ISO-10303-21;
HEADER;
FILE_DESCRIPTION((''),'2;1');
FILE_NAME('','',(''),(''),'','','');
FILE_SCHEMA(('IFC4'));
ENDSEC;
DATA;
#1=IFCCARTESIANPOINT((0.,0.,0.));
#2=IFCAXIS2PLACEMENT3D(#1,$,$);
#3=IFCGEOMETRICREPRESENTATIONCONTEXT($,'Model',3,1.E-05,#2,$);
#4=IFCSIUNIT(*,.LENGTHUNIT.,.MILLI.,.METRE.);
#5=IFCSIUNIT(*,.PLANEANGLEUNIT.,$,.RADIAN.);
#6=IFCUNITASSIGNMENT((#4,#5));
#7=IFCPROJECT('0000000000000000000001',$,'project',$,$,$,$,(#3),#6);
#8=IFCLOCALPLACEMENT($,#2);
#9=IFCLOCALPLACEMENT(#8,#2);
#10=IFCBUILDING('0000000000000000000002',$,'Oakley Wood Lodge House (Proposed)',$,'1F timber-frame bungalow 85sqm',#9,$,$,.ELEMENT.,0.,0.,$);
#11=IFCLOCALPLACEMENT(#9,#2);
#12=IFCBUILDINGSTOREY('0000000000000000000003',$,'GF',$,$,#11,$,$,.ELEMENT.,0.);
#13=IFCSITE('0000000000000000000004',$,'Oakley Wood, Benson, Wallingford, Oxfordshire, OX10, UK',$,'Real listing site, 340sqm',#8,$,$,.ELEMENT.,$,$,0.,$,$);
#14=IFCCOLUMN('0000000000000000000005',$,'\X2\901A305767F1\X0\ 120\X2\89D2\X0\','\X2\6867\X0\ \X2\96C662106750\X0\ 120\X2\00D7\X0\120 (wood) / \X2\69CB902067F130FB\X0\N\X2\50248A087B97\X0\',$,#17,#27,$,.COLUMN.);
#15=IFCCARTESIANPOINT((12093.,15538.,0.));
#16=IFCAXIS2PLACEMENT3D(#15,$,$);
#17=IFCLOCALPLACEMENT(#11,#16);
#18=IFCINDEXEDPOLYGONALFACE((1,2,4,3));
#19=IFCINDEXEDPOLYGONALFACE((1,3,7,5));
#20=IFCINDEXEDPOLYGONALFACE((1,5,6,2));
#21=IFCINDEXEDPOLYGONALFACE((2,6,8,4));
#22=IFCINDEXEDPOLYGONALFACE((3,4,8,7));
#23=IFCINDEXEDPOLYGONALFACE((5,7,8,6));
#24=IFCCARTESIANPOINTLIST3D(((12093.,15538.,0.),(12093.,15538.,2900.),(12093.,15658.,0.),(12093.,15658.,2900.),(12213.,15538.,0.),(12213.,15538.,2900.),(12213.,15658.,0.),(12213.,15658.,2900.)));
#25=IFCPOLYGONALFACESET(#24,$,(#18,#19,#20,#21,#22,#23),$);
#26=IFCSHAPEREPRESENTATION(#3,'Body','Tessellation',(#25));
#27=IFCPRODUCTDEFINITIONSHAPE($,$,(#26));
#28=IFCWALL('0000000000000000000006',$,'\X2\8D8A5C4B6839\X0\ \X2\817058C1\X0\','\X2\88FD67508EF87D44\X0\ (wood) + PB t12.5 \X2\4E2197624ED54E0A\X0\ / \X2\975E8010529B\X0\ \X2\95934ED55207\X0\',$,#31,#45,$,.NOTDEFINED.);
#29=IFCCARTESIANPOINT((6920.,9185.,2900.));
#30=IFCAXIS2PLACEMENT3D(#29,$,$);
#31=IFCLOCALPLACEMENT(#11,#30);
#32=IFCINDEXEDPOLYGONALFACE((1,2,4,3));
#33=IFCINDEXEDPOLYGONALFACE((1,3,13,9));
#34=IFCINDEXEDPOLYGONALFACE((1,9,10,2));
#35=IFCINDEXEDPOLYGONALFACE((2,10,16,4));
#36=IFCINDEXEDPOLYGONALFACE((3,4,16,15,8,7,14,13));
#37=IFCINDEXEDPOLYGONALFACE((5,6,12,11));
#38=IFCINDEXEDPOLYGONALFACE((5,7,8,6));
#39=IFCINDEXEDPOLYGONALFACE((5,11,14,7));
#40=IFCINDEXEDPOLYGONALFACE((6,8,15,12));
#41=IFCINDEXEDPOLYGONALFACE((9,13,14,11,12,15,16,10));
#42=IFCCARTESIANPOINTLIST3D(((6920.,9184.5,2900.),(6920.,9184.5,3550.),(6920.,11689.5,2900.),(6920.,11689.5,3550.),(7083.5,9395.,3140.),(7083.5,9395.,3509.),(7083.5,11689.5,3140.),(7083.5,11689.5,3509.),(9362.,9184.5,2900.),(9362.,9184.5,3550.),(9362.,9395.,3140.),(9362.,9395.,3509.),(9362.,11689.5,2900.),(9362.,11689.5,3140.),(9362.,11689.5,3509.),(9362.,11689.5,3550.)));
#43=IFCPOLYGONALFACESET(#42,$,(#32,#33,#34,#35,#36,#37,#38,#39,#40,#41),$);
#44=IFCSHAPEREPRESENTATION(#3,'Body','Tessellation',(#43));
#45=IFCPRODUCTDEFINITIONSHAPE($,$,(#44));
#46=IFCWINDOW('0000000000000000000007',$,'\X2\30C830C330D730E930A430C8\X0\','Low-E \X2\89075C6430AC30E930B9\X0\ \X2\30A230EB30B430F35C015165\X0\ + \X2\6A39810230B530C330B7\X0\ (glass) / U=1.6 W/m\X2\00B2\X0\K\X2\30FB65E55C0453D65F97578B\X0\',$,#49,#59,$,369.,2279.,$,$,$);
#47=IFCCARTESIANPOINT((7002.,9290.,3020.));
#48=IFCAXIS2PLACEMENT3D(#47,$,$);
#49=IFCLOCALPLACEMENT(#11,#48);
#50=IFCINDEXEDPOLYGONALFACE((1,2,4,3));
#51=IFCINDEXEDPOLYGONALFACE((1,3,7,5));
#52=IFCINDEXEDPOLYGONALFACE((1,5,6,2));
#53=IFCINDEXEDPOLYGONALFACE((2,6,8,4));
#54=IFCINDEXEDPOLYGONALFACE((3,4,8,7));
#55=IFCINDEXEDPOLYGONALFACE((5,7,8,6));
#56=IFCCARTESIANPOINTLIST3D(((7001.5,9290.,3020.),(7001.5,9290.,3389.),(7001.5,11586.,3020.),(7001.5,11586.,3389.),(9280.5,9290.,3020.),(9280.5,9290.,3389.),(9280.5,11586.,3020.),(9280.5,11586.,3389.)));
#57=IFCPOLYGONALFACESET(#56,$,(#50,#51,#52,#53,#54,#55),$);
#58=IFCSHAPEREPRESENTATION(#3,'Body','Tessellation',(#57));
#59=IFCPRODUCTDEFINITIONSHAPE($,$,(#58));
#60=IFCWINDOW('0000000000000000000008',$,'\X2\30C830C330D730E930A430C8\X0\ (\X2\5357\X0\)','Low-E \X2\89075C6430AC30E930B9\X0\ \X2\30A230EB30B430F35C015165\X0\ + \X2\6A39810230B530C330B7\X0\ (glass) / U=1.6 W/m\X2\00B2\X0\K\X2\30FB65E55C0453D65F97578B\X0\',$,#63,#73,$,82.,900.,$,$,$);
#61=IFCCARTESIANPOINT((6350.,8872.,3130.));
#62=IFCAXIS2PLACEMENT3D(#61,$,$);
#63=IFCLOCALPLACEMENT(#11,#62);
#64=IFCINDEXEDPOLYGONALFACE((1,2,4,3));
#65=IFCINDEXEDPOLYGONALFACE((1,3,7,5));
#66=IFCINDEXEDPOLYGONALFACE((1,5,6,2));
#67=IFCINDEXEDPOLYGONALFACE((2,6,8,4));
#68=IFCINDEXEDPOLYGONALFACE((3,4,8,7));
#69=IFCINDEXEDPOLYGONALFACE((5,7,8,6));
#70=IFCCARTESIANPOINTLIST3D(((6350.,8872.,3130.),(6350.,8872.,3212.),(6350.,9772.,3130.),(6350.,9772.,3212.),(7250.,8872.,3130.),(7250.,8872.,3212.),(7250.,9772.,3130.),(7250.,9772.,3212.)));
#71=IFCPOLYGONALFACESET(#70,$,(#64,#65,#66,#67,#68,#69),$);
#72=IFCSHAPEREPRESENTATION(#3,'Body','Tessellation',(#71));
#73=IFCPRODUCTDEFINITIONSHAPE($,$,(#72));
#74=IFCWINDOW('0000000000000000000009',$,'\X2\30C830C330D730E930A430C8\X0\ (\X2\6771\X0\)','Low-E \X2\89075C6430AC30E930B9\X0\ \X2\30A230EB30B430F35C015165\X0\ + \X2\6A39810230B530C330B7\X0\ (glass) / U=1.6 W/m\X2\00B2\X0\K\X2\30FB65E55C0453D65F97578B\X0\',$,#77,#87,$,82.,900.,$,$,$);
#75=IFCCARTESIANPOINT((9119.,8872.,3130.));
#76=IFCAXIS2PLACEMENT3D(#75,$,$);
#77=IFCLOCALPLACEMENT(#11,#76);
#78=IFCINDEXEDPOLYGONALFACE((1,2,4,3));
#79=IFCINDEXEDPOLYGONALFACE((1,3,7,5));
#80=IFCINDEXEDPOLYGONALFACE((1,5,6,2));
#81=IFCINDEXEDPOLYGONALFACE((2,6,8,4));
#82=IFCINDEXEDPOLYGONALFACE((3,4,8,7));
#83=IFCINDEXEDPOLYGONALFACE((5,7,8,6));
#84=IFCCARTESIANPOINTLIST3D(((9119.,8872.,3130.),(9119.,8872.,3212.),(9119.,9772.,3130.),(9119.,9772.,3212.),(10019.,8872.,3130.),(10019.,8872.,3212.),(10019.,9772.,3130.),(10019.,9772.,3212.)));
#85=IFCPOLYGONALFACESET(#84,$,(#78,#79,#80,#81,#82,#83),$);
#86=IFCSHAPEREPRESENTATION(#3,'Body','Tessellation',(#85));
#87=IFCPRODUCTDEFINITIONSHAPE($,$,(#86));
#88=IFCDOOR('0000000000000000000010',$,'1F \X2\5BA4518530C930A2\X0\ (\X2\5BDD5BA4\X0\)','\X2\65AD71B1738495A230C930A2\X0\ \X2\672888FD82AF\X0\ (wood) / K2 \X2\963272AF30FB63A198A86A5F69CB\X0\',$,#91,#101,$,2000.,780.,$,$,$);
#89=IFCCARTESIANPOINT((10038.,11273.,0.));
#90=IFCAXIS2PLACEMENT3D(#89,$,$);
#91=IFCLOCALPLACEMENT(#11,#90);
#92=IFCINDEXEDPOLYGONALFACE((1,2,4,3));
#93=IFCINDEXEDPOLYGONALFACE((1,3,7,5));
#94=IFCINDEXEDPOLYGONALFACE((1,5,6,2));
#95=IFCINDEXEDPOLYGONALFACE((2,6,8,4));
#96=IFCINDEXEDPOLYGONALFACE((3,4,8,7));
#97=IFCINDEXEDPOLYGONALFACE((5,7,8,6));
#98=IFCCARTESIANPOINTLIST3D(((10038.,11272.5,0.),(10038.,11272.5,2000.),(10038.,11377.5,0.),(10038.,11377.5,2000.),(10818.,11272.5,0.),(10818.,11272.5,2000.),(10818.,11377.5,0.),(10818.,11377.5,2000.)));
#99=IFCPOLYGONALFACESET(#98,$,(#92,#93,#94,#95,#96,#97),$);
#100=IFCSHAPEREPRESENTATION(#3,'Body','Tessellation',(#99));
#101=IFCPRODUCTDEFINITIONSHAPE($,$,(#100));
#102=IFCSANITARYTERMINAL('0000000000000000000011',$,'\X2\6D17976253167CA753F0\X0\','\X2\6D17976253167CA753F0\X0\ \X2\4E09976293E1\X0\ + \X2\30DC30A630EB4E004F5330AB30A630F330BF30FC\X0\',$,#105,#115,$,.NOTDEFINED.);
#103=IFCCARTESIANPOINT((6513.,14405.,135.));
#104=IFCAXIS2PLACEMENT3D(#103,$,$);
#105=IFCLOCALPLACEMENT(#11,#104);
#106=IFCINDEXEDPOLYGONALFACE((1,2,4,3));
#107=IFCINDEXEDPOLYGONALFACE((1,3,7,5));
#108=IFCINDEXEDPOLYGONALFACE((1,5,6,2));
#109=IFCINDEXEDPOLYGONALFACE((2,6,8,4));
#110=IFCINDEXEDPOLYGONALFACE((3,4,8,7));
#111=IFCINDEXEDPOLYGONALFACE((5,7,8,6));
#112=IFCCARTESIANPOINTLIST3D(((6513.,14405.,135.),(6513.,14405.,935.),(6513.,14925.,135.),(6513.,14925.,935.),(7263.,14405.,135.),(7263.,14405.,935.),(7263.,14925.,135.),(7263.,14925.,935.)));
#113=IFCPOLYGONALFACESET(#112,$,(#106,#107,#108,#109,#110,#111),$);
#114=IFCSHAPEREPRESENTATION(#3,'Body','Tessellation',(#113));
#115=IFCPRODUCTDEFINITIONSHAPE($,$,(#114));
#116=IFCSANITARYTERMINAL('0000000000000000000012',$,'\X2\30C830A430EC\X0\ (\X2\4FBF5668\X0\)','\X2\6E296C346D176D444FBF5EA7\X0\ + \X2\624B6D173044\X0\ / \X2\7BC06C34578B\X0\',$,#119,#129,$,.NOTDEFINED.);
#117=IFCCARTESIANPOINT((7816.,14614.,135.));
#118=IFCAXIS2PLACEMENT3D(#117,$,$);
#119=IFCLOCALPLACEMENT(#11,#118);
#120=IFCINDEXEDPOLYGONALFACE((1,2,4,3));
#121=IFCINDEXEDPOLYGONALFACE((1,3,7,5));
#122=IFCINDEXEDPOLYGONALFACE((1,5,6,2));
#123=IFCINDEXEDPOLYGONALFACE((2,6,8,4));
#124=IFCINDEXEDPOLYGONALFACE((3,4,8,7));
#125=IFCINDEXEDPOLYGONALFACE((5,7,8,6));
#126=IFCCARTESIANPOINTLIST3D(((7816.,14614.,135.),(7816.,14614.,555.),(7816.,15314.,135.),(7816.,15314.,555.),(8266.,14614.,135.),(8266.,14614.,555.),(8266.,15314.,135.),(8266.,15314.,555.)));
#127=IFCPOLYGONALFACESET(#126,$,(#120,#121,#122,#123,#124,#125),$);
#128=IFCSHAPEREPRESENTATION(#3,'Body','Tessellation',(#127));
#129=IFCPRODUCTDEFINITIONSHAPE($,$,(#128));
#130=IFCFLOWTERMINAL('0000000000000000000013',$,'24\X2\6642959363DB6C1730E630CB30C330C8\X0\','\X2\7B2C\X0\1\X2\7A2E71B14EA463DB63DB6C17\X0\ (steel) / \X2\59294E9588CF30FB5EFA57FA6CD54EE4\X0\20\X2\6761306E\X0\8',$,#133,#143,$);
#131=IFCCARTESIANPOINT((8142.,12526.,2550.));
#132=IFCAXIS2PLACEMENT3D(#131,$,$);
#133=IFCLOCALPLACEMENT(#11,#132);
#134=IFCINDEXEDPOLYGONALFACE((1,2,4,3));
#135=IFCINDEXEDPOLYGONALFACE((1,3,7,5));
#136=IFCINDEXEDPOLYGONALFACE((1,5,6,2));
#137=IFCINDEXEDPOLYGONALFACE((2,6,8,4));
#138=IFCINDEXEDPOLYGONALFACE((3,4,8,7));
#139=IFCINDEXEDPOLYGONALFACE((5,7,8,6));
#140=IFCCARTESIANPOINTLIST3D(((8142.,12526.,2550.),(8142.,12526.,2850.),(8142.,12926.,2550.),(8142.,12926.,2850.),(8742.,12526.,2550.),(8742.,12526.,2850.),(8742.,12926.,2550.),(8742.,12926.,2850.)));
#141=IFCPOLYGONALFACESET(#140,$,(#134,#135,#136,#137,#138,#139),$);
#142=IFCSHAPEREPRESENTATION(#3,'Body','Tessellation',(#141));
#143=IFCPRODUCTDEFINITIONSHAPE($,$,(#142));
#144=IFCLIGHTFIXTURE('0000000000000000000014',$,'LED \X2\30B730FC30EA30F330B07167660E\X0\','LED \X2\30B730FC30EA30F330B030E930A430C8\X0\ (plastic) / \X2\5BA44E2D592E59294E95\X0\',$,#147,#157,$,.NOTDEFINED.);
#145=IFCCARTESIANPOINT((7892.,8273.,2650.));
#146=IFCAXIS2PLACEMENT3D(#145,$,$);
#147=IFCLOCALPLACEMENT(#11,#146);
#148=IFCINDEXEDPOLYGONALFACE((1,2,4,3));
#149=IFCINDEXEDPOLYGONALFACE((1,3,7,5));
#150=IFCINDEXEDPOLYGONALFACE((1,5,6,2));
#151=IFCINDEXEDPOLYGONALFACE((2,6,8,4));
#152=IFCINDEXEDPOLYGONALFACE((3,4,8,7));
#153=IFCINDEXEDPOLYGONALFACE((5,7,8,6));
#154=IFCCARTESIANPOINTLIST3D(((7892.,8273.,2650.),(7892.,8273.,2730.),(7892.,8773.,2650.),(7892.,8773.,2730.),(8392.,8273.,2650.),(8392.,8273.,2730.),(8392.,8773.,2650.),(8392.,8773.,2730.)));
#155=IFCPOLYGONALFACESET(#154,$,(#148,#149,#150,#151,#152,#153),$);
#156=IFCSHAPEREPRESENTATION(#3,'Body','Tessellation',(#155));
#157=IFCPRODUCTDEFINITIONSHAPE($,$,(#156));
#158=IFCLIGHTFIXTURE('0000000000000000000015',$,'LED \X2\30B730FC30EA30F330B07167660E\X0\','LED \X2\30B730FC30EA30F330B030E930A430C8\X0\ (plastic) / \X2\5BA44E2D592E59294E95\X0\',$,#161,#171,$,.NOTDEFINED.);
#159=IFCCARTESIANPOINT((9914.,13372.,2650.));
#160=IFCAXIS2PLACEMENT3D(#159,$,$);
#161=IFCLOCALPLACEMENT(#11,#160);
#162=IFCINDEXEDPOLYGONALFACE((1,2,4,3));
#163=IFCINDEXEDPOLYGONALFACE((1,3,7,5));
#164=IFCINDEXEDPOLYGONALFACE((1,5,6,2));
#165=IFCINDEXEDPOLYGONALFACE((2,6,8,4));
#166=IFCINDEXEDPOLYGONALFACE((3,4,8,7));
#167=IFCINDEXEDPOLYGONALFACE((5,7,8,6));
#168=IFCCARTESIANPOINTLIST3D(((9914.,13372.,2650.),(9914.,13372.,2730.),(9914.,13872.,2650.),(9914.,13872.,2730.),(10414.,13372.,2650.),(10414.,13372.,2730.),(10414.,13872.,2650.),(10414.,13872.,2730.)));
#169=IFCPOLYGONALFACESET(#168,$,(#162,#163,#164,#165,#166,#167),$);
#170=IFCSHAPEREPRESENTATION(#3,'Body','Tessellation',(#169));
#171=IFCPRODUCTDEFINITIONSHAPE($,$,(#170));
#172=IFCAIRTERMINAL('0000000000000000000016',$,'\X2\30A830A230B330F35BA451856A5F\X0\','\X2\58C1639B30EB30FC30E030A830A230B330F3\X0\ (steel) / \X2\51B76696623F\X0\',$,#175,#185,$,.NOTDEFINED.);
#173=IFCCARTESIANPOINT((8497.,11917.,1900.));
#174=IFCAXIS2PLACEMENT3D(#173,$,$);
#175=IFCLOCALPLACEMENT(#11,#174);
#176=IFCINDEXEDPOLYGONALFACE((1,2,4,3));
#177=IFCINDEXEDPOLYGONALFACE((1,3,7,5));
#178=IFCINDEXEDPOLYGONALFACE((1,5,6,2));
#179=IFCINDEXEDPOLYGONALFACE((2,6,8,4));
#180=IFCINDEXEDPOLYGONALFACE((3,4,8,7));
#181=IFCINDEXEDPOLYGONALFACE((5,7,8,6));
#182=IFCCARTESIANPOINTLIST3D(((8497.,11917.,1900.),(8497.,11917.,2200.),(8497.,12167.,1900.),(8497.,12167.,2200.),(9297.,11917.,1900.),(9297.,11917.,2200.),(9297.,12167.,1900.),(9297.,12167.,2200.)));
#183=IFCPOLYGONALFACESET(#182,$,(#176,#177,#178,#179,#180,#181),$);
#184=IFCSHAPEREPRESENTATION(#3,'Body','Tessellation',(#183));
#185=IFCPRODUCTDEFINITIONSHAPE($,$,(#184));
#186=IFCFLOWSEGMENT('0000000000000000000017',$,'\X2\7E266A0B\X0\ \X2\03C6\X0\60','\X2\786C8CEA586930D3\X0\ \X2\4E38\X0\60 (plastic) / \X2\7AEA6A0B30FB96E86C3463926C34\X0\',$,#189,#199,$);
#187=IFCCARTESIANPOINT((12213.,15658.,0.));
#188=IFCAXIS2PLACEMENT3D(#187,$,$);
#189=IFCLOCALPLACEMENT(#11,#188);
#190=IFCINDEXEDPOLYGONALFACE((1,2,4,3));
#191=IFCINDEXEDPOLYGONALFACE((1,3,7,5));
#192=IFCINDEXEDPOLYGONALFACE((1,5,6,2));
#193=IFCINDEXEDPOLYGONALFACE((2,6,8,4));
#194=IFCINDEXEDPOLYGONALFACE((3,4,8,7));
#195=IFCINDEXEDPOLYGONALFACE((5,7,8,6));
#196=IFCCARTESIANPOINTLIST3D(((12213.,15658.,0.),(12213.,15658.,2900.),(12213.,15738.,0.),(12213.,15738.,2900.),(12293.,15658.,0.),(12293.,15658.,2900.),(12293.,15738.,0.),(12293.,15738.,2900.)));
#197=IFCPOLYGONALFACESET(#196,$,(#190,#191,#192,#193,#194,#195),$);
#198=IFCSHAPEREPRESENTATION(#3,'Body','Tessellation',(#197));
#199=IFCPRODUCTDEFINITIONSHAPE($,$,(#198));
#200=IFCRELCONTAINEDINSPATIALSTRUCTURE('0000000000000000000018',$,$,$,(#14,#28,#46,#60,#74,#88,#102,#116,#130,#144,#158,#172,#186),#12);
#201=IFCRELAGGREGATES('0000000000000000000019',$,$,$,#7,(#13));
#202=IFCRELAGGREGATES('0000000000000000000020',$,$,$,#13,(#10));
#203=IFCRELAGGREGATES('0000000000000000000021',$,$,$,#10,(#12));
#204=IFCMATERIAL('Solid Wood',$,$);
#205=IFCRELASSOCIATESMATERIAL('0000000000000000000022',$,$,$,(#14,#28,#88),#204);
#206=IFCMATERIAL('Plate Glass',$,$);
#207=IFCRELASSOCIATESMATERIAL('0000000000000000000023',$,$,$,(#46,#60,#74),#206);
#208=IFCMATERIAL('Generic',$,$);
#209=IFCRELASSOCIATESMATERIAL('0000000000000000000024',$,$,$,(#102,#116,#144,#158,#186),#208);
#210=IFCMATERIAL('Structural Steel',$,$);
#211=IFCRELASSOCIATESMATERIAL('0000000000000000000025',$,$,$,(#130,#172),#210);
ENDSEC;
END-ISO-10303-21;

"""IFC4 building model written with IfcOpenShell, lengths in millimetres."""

from ifc_helpers import new_model, si_unit, frame, frame_2d, origin, place, context, project, spatial, rectangle, extrude, material, element, fill, save


model = new_model("IFC4")

# Units and contexts
model_context = context("Model", 3, precision=1e-05, world=origin())
ifc_project = project(units=[si_unit("LENGTHUNIT", "METRE", prefix="MILLI"), si_unit("PLANEANGLEUNIT", "RADIAN")], contexts=[model_context])

# Site, building, storey
site_placement = place(None, origin())
site = spatial("IfcSite", under=ifc_project, at=site_placement, Name="Oakley Wood, Benson, Wallingford, Oxfordshire, OX10, UK", ObjectType="Real listing site, 340sqm", CompositionType="ELEMENT", RefElevation=0.0)
building_placement = place(site_placement, origin())
building = spatial("IfcBuilding", under=site, at=building_placement, Name="Oakley Wood Lodge House (Proposed)", ObjectType="1F timber-frame bungalow 85sqm", CompositionType="ELEMENT", ElevationOfRefHeight=0.0, ElevationOfTerrain=0.0)
storey_placement = place(building_placement, origin())
storey = spatial("IfcBuildingStorey", under=building, at=storey_placement, Name="GF", CompositionType="ELEMENT", Elevation=0.0)

# Column
ifc_material_1 = material(Name="Solid Wood")
column_1_placement = place(storey_placement, frame((12093.0, 15538.0, 0.0)))
element("IfcColumn", 1, at=column_1_placement, inside=storey, material=ifc_material_1, Name="通し柱 120角", Description="桧 集成材 120×120 (wood) / 構造柱・N値計算", PredefinedType="COLUMN", context=model_context, shape_type="SweptSolid", body=[
    extrude(rectangle(XDim=120.0, YDim=120.0, at=frame_2d((60.0, 60.0))), frame((12093.0, 15538.0, 0.0)), (0.0, 0.0, 1.0), 2900.0),
])

# Wall, openings, windows
wall_1_placement = place(storey_placement, frame((6920.0, 9185.0, 2900.0)))
wall_1 = element("IfcWall", 2, at=wall_1_placement, inside=storey, material=ifc_material_1, Name="越屋根 腰壁", Description="製材軸組 (wood) + PB t12.5 両面仕上 / 非耐力 間仕切", PredefinedType="NOTDEFINED", context=model_context, shape_type="SweptSolid", body=[
    extrude(rectangle(XDim=2442.0, YDim=2505.0, at=frame_2d((1221.0, 1252.0))), frame((6920.0, 9185.0, 2900.0)), (0.0, 0.0, 1.0), 650.0),
])
opening_1_placement = place(storey_placement, frame((7002.0, 9290.0, 3020.0)))
opening_1 = element("IfcOpeningElement", 3, at=opening_1_placement, cuts=wall_1, PredefinedType="NOTDEFINED", context=model_context, shape_type="SweptSolid", body=[
    extrude(rectangle(XDim=2279.0, YDim=2296.0, at=frame_2d((1139.0, 1148.0))), frame((7002.0, 9290.0, 3020.0)), (0.0, 0.0, 1.0), 369.0),
])
opening_2_placement = place(storey_placement, frame((6350.0, 8872.0, 3130.0)))
opening_2 = element("IfcOpeningElement", 4, at=opening_2_placement, cuts=wall_1, PredefinedType="NOTDEFINED", context=model_context, shape_type="SweptSolid", body=[
    extrude(rectangle(XDim=900.0, YDim=900.0, at=frame_2d((450.0, 450.0))), frame((6350.0, 8872.0, 3130.0)), (0.0, 0.0, 1.0), 82.0),
])
opening_3_placement = place(storey_placement, frame((9119.0, 8872.0, 3130.0)))
opening_3 = element("IfcOpeningElement", 5, at=opening_3_placement, cuts=wall_1, PredefinedType="NOTDEFINED", context=model_context, shape_type="SweptSolid", body=[
    extrude(rectangle(XDim=900.0, YDim=900.0, at=frame_2d((450.0, 450.0))), frame((9119.0, 8872.0, 3130.0)), (0.0, 0.0, 1.0), 82.0),
])
ifc_material_2 = material(Name="Plate Glass")
window_1_placement = place(storey_placement, frame((7002.0, 9290.0, 3020.0)))
window_1 = element("IfcWindow", 6, at=window_1_placement, inside=storey, material=ifc_material_2, Name="トップライト", Description="Low-E 複層ガラス アルゴン封入 + 樹脂サッシ (glass) / U=1.6 W/m²K・日射取得型", OverallHeight=369.0, OverallWidth=2279.0, context=model_context, shape_type="SweptSolid", body=[
    extrude(rectangle(XDim=2279.0, YDim=2296.0, at=frame_2d((1139.0, 1148.0))), frame((7002.0, 9290.0, 3020.0)), (0.0, 0.0, 1.0), 369.0),
])
fill(opening_1, window_1)
window_2_placement = place(storey_placement, frame((6350.0, 8872.0, 3130.0)))
window_2 = element("IfcWindow", 7, at=window_2_placement, inside=storey, material=ifc_material_2, Name="トップライト (南)", Description="Low-E 複層ガラス アルゴン封入 + 樹脂サッシ (glass) / U=1.6 W/m²K・日射取得型", OverallHeight=82.0, OverallWidth=900.0, context=model_context, shape_type="SweptSolid", body=[
    extrude(rectangle(XDim=900.0, YDim=900.0, at=frame_2d((450.0, 450.0))), frame((6350.0, 8872.0, 3130.0)), (0.0, 0.0, 1.0), 82.0),
])
fill(opening_2, window_2)
window_3_placement = place(storey_placement, frame((9119.0, 8872.0, 3130.0)))
window_3 = element("IfcWindow", 8, at=window_3_placement, inside=storey, material=ifc_material_2, Name="トップライト (東)", Description="Low-E 複層ガラス アルゴン封入 + 樹脂サッシ (glass) / U=1.6 W/m²K・日射取得型", OverallHeight=82.0, OverallWidth=900.0, context=model_context, shape_type="SweptSolid", body=[
    extrude(rectangle(XDim=900.0, YDim=900.0, at=frame_2d((450.0, 450.0))), frame((9119.0, 8872.0, 3130.0)), (0.0, 0.0, 1.0), 82.0),
])
fill(opening_3, window_3)

# Door
door_placement = place(storey_placement, frame((10038.0, 11273.0, 0.0)))
element("IfcDoor", 9, at=door_placement, inside=storey, material=ifc_material_1, Name="1F 室内ドア (寝室)", Description="断熱玄関ドア 木製芯 (wood) / K2 防犯・採風機構", OverallHeight=2000.0, OverallWidth=780.0, context=model_context, shape_type="SweptSolid", body=[
    extrude(rectangle(XDim=780.0, YDim=105.0, at=frame_2d((390.0, 52.0))), frame((10038.0, 11273.0, 0.0)), (0.0, 0.0, 1.0), 2000.0),
])

# Shared definitions
ifc_material_3 = material(Name="Structural Steel")

# Sanitary terminals
ifc_material_4 = material(Name="Generic")
sanitary_terminal_1_placement = place(storey_placement, frame((6513.0, 14405.0, 135.0)))
element("IfcSanitaryTerminal", 10, at=sanitary_terminal_1_placement, inside=storey, material=ifc_material_4, Name="洗面化粧台", Description="洗面化粧台 三面鏡 + ボウル一体カウンター", PredefinedType="NOTDEFINED", context=model_context, shape_type="SweptSolid", body=[
    extrude(rectangle(XDim=750.0, YDim=520.0, at=frame_2d((375.0, 260.0))), frame((6513.0, 14405.0, 135.0)), (0.0, 0.0, 1.0), 800.0),
])
sanitary_terminal_2_placement = place(storey_placement, frame((7816.0, 14614.0, 135.0)))
element("IfcSanitaryTerminal", 11, at=sanitary_terminal_2_placement, inside=storey, material=ifc_material_4, Name="トイレ (便器)", Description="温水洗浄便座 + 手洗い / 節水型", PredefinedType="NOTDEFINED", context=model_context, shape_type="SweptSolid", body=[
    extrude(rectangle(XDim=450.0, YDim=700.0, at=frame_2d((225.0, 350.0))), frame((7816.0, 14614.0, 135.0)), (0.0, 0.0, 1.0), 420.0),
])

# Flow terminal
flow_terminal_placement = place(storey_placement, frame((8142.0, 12526.0, 2550.0)))
element("IfcFlowTerminal", 12, at=flow_terminal_placement, inside=storey, material=ifc_material_3, Name="24時間換気ユニット", Description="第1種熱交換換気 (steel) / 天井裏・建基法令20条の8", context=model_context, shape_type="SweptSolid", body=[
    extrude(rectangle(XDim=600.0, YDim=400.0, at=frame_2d((300.0, 200.0))), frame((8142.0, 12526.0, 2550.0)), (0.0, 0.0, 1.0), 300.0),
])

# Light fixtures
light_fixture_1_placement = place(storey_placement, frame((7892.0, 8273.0, 2650.0)))
element("IfcLightFixture", 13, at=light_fixture_1_placement, inside=storey, material=ifc_material_4, Name="LED シーリング照明", Description="LED シーリングライト (plastic) / 室中央天井", PredefinedType="NOTDEFINED", context=model_context, shape_type="SweptSolid", body=[
    extrude(rectangle(XDim=500.0, YDim=500.0, at=frame_2d((250.0, 250.0))), frame((7892.0, 8273.0, 2650.0)), (0.0, 0.0, 1.0), 80.0),
])
light_fixture_2_placement = place(storey_placement, frame((9914.0, 13372.0, 2650.0)))
element("IfcLightFixture", 14, at=light_fixture_2_placement, inside=storey, material=ifc_material_4, Name="LED シーリング照明", Description="LED シーリングライト (plastic) / 室中央天井", PredefinedType="NOTDEFINED", context=model_context, shape_type="SweptSolid", body=[
    extrude(rectangle(XDim=500.0, YDim=500.0, at=frame_2d((250.0, 250.0))), frame((9914.0, 13372.0, 2650.0)), (0.0, 0.0, 1.0), 80.0),
])

# Air terminal
air_terminal_placement = place(storey_placement, frame((8497.0, 11917.0, 1900.0)))
element("IfcAirTerminal", 15, at=air_terminal_placement, inside=storey, material=ifc_material_3, Name="エアコン室内機", Description="壁掛ルームエアコン (steel) / 冷暖房", PredefinedType="NOTDEFINED", context=model_context, shape_type="SweptSolid", body=[
    extrude(rectangle(XDim=800.0, YDim=250.0, at=frame_2d((400.0, 125.0))), frame((8497.0, 11917.0, 1900.0)), (0.0, 0.0, 1.0), 300.0),
])

# Flow segment
flow_segment_placement = place(storey_placement, frame((12213.0, 15658.0, 0.0)))
element("IfcFlowSegment", 16, at=flow_segment_placement, inside=storey, material=ifc_material_4, Name="縦樋 φ60", Description="硬質塩ビ 丸60 (plastic) / 竪樋・雨水排水", context=model_context, shape_type="SweptSolid", body=[
    extrude(rectangle(XDim=80.0, YDim=80.0, at=frame_2d((40.0, 40.0))), frame((12213.0, 15658.0, 0.0)), (0.0, 0.0, 1.0), 2900.0),
])

save(model, "model.ifc")
